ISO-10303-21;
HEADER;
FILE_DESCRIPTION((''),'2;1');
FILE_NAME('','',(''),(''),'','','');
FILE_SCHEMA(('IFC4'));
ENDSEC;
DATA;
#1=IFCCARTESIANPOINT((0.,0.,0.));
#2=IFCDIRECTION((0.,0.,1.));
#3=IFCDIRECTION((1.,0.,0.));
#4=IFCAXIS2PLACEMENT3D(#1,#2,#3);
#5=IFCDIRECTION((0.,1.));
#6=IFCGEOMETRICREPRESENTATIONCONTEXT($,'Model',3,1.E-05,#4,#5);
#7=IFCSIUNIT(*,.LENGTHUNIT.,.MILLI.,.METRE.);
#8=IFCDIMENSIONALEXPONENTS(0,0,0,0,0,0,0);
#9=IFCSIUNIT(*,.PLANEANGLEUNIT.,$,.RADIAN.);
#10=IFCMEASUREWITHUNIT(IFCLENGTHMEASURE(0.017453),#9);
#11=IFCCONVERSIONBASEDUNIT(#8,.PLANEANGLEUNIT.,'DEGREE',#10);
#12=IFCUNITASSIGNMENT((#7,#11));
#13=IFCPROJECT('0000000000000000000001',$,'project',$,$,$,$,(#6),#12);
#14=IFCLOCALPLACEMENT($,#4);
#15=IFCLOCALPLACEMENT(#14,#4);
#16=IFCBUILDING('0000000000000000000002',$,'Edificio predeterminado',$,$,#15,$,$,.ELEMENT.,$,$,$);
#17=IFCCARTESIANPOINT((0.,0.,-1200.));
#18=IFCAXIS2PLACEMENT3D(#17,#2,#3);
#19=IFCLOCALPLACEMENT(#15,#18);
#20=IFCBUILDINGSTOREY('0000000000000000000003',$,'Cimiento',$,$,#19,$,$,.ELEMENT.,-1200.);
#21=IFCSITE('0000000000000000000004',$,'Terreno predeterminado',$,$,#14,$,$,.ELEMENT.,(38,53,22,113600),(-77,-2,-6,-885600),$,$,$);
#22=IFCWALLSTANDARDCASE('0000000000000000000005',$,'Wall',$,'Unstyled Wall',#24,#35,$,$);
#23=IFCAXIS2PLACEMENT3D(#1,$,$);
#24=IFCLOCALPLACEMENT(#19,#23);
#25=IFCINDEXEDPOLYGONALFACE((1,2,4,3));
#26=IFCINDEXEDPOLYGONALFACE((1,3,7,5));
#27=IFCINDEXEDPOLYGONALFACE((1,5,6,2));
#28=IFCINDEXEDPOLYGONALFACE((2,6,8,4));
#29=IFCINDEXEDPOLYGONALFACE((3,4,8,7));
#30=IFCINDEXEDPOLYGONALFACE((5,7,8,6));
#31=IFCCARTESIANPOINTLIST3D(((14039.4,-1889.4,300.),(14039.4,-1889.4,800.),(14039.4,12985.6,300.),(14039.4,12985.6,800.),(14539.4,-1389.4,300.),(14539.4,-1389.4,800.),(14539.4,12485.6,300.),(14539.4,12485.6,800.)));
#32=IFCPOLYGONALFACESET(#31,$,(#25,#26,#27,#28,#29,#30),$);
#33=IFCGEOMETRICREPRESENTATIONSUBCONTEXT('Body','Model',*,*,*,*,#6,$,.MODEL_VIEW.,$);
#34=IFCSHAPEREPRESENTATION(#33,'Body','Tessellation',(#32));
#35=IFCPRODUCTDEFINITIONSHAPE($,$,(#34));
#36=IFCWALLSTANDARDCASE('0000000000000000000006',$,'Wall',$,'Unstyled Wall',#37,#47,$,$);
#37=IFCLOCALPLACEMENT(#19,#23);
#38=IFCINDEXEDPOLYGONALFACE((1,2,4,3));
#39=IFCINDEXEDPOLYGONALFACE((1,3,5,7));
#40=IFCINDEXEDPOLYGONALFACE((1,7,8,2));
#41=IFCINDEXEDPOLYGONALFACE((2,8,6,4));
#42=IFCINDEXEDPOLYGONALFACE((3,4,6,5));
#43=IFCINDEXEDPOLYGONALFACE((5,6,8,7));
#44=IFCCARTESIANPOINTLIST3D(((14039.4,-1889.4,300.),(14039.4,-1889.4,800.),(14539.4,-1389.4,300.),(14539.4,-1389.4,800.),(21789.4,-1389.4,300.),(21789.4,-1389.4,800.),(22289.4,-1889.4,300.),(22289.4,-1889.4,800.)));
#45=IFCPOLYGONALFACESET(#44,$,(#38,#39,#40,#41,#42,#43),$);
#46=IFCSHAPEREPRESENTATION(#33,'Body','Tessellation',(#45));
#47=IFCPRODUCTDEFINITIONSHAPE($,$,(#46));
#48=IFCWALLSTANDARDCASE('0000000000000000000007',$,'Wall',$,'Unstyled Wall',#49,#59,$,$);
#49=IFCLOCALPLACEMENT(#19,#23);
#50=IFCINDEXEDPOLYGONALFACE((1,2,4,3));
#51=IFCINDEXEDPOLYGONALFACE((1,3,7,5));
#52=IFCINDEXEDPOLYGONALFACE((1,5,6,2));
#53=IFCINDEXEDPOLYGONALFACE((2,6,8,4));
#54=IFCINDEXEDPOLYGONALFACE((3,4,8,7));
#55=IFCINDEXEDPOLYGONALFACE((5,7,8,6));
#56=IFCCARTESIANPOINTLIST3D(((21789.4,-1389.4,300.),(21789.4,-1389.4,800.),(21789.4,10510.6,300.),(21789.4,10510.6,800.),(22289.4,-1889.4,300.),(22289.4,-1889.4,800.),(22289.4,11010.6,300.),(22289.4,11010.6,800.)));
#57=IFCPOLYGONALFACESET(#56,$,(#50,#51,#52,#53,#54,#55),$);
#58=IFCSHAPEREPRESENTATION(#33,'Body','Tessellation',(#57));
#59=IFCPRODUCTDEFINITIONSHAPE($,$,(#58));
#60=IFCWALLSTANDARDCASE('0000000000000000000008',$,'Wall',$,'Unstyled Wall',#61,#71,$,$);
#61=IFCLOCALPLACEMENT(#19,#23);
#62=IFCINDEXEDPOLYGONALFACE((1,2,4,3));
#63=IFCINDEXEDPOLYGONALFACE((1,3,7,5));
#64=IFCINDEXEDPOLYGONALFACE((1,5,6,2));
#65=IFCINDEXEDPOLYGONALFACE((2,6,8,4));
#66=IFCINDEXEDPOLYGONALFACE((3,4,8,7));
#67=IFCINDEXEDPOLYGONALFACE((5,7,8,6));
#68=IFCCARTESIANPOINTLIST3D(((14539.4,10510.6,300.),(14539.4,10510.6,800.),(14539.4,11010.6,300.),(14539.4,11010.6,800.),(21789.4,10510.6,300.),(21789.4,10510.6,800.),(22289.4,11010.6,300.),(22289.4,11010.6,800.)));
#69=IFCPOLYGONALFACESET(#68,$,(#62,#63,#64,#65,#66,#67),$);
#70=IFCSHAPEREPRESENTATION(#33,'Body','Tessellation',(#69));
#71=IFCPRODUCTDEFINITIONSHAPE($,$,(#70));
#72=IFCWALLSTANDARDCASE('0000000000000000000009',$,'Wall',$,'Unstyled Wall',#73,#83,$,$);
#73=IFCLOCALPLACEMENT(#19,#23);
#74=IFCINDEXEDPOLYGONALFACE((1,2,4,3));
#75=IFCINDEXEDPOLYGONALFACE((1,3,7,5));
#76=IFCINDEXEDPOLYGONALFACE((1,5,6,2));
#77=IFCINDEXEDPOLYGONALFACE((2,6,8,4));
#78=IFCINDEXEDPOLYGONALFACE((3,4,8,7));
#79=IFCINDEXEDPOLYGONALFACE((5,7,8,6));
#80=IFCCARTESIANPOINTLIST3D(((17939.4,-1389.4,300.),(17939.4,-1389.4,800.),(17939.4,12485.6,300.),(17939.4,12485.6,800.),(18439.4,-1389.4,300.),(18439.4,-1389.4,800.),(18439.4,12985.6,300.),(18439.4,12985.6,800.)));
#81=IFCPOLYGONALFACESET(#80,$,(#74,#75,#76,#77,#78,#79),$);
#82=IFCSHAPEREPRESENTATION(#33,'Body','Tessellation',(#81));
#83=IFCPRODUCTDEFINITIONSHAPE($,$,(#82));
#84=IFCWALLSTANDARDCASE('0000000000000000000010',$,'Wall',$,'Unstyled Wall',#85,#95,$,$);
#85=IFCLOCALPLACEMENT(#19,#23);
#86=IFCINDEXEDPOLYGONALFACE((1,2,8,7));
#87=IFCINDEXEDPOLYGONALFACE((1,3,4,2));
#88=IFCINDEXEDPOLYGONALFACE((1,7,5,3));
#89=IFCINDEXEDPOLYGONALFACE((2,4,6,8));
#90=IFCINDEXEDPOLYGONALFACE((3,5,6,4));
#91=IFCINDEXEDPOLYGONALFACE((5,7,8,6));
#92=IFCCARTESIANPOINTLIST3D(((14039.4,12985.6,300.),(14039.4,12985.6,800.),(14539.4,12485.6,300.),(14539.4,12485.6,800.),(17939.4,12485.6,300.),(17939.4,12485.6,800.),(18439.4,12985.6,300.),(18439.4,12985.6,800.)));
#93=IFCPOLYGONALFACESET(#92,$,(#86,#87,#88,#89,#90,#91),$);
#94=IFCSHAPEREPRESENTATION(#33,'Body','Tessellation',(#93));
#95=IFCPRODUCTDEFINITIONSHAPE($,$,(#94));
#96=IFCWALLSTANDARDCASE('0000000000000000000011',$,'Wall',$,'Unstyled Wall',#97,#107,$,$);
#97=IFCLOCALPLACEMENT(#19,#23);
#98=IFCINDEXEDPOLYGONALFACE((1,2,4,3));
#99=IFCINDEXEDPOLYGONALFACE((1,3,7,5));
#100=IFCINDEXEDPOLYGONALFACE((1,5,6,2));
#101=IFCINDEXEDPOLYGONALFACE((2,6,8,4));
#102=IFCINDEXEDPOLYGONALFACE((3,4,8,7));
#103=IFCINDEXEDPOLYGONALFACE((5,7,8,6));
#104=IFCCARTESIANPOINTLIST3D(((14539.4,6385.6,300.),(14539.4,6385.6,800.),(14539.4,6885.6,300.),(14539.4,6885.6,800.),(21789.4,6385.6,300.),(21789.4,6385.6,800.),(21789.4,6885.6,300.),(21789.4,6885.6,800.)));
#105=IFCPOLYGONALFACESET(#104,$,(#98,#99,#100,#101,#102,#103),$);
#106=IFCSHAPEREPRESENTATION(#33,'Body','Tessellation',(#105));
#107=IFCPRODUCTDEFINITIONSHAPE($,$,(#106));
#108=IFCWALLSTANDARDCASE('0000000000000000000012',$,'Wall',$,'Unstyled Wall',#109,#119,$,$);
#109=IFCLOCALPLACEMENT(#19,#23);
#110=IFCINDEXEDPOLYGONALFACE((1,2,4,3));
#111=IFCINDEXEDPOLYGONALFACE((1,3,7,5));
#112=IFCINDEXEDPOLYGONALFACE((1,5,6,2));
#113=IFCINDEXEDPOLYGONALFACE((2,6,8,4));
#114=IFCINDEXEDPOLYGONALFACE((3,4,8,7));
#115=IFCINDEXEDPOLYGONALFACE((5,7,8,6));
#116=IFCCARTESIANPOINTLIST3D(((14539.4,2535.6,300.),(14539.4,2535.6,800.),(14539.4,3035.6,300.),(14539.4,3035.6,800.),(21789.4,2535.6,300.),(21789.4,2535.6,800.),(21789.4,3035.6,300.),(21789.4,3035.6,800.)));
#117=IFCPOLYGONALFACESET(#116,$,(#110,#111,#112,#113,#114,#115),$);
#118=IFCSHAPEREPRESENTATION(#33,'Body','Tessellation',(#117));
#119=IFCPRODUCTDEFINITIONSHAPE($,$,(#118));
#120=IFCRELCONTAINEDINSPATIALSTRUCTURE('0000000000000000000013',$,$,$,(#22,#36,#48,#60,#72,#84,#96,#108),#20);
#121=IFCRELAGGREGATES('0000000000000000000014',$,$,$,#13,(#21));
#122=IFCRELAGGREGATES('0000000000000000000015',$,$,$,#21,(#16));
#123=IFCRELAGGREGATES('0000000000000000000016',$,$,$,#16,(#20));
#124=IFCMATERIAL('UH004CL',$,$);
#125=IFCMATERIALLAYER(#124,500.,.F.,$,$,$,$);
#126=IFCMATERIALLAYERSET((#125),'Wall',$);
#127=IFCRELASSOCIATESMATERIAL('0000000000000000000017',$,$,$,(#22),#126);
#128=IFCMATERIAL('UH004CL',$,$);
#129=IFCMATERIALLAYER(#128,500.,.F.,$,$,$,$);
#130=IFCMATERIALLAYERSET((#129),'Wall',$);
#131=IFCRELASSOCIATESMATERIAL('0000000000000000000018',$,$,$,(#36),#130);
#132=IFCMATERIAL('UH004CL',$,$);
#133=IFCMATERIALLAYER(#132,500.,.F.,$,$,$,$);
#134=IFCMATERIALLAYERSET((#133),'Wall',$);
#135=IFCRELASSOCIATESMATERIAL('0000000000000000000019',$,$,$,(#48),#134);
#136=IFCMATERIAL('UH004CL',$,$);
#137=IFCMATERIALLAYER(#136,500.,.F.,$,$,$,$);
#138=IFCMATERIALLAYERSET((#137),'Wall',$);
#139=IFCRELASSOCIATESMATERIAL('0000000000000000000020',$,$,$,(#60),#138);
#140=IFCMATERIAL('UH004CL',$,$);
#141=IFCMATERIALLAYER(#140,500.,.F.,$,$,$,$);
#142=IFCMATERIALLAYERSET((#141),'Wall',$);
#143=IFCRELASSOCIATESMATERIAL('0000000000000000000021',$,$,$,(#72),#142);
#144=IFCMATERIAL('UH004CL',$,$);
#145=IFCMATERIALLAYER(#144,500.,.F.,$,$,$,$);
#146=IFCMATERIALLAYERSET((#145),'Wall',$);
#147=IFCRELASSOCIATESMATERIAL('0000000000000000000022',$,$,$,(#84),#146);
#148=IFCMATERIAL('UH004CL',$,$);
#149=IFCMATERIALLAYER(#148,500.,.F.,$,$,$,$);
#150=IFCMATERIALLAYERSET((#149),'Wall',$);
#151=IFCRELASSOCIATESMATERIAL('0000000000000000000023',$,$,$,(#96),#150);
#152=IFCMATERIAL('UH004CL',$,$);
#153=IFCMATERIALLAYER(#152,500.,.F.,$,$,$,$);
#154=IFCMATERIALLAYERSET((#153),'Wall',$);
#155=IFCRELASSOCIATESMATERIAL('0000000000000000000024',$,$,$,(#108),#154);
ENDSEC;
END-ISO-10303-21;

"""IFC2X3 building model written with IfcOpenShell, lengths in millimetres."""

from ifc_helpers import new_model, entity, si_unit, converted_unit, direction, frame, origin_with_axes, place, context, subcontext, project, spatial, polyline, outline, extrude, material, layer, layer_set, layer_usage, element, save


model = new_model("IFC2X3")

# Units and contexts
model_context = context("Model", 3, precision=1e-05, world=origin_with_axes(), true_north=direction((0.0, 1.0)))
body_context = subcontext(model_context, "Body", "Model", "MODEL_VIEW")
ifc_project = project(units=[si_unit("LENGTHUNIT", "METRE", prefix="MILLI"), converted_unit("PLANEANGLEUNIT", "DEGREE", entity("IfcLengthMeasure", 0.017453), si_unit("PLANEANGLEUNIT", "RADIAN"), dimensions=[0, 0, 0, 0, 0, 0, 0])], contexts=[model_context])

# Site, building, storey
site_placement = place(None, origin_with_axes())
site = spatial("IfcSite", under=ifc_project, at=site_placement, Name="Terreno predeterminado", CompositionType="ELEMENT", RefLatitude=(38, 53, 22, 113600), RefLongitude=(-77, -2, -6, -885600))
building_placement = place(site_placement, origin_with_axes())
building = spatial("IfcBuilding", under=site, at=building_placement, Name="Edificio predeterminado", CompositionType="ELEMENT")
storey_placement = place(building_placement, frame((0.0, 0.0, -1200.0), z_axis=(0.0, 0.0, 1.0), x_axis=(1.0, 0.0, 0.0)))
storey = spatial("IfcBuildingStorey", under=building, at=storey_placement, Name="Cimiento", CompositionType="ELEMENT", Elevation=-1200.0)

# Walls
ifc_material_1 = material(Name="UH004CL")
ifc_layer_1 = layer(ifc_material_1, 500.0, ventilated=False)
ifc_layer_set_1 = layer_set([ifc_layer_1], Name="Wall")
ifc_layer_usage_1 = layer_usage(ifc_layer_set_1, "AXIS2", "POSITIVE", -250.0)
wall_1_placement = place(storey_placement, frame((14289.4, 12735.6, 300.0), z_axis=(0.0, 0.0, 1.0), x_axis=(0.0, -1.0, 0.0)))
element("IfcWallStandardCase", 1, at=wall_1_placement, inside=storey, material=ifc_layer_usage_1, Name="Wall", ObjectType="Unstyled Wall", context=body_context, shape_type="SweptSolid", body=[
    extrude(outline(polyline([(250.0, 250.0), (-250.0, -250.0), (14625.0, -250.0), (14125.0, 250.0), (250.0, 250.0)])), origin_with_axes(), (0.0, 0.0, 1.0), 500.0),
])
ifc_material_2 = material(Name="UH004CL")
ifc_layer_2 = layer(ifc_material_2, 500.0, ventilated=False)
ifc_layer_set_2 = layer_set([ifc_layer_2], Name="Wall")
ifc_layer_usage_2 = layer_usage(ifc_layer_set_2, "AXIS2", "POSITIVE", -250.0)
wall_2_placement = place(storey_placement, frame((14289.4, -1639.4, 300.0), z_axis=(0.0, 0.0, 1.0), x_axis=(1.0, 0.0, 0.0)))
element("IfcWallStandardCase", 2, at=wall_2_placement, inside=storey, material=ifc_layer_usage_2, Name="Wall", ObjectType="Unstyled Wall", context=body_context, shape_type="SweptSolid", body=[
    extrude(outline(polyline([(-250.0, -250.0), (250.0, 250.0), (7500.0, 250.0), (8000.0, -250.0), (-250.0, -250.0)])), origin_with_axes(), (0.0, 0.0, 1.0), 500.0),
])
ifc_material_3 = material(Name="UH004CL")
ifc_layer_3 = layer(ifc_material_3, 500.0, ventilated=False)
ifc_layer_set_3 = layer_set([ifc_layer_3], Name="Wall")
ifc_layer_usage_3 = layer_usage(ifc_layer_set_3, "AXIS2", "POSITIVE", -250.0)
wall_3_placement = place(storey_placement, frame((22039.4, -1639.4, 300.0), z_axis=(0.0, 0.0, 1.0), x_axis=(0.0, 1.0, 0.0)))
element("IfcWallStandardCase", 3, at=wall_3_placement, inside=storey, material=ifc_layer_usage_3, Name="Wall", ObjectType="Unstyled Wall", context=body_context, shape_type="SweptSolid", body=[
    extrude(outline(polyline([(-250.0, -250.0), (250.0, 250.0), (12150.0, 250.0), (12650.0, -250.0), (-250.0, -250.0)])), origin_with_axes(), (0.0, 0.0, 1.0), 500.0),
])
ifc_material_4 = material(Name="UH004CL")
ifc_layer_4 = layer(ifc_material_4, 500.0, ventilated=False)
ifc_layer_set_4 = layer_set([ifc_layer_4], Name="Wall")
ifc_layer_usage_4 = layer_usage(ifc_layer_set_4, "AXIS2", "POSITIVE", -250.0)
wall_4_placement = place(storey_placement, frame((22039.4, 10760.6, 300.0), z_axis=(0.0, 0.0, 1.0), x_axis=(-1.0, 0.0, 0.0)))
element("IfcWallStandardCase", 4, at=wall_4_placement, inside=storey, material=ifc_layer_usage_4, Name="Wall", ObjectType="Unstyled Wall", context=body_context, shape_type="SweptSolid", body=[
    extrude(outline(polyline([(-250.0, -250.0), (250.0, 250.0), (7500.0, 250.0), (7500.0, -250.0), (-250.0, -250.0)])), origin_with_axes(), (0.0, 0.0, 1.0), 500.0),
])
ifc_material_5 = material(Name="UH004CL")
ifc_layer_5 = layer(ifc_material_5, 500.0, ventilated=False)
ifc_layer_set_5 = layer_set([ifc_layer_5], Name="Wall")
ifc_layer_usage_5 = layer_usage(ifc_layer_set_5, "AXIS2", "POSITIVE", -250.0)
wall_5_placement = place(storey_placement, frame((18189.4, -1639.4, 300.0), z_axis=(0.0, 0.0, 1.0), x_axis=(0.0, 1.0, 0.0)))
element("IfcWallStandardCase", 5, at=wall_5_placement, inside=storey, material=ifc_layer_usage_5, Name="Wall", ObjectType="Unstyled Wall", context=body_context, shape_type="SweptSolid", body=[
    extrude(outline(polyline([(250.0, 250.0), (250.0, -250.0), (14625.0, -250.0), (14125.0, 250.0), (250.0, 250.0)])), origin_with_axes(), (0.0, 0.0, 1.0), 500.0),
])
ifc_material_6 = material(Name="UH004CL")
ifc_layer_6 = layer(ifc_material_6, 500.0, ventilated=False)
ifc_layer_set_6 = layer_set([ifc_layer_6], Name="Wall")
ifc_layer_usage_6 = layer_usage(ifc_layer_set_6, "AXIS2", "POSITIVE", -250.0)
wall_6_placement = place(storey_placement, frame((18189.4, 12735.6, 300.0), z_axis=(0.0, 0.0, 1.0), x_axis=(-1.0, 0.0, 0.0)))
element("IfcWallStandardCase", 6, at=wall_6_placement, inside=storey, material=ifc_layer_usage_6, Name="Wall", ObjectType="Unstyled Wall", context=body_context, shape_type="SweptSolid", body=[
    extrude(outline(polyline([(-250.0, -250.0), (250.0, 250.0), (3650.0, 250.0), (4150.0, -250.0), (-250.0, -250.0)])), origin_with_axes(), (0.0, 0.0, 1.0), 500.0),
])
ifc_material_7 = material(Name="UH004CL")
ifc_layer_7 = layer(ifc_material_7, 500.0, ventilated=False)
ifc_layer_set_7 = layer_set([ifc_layer_7], Name="Wall")
ifc_layer_usage_7 = layer_usage(ifc_layer_set_7, "AXIS2", "POSITIVE", -250.0)
wall_7_placement = place(storey_placement, frame((14289.4, 6635.6, 300.0), z_axis=(0.0, 0.0, 1.0), x_axis=(1.0, 0.0, 0.0)))
element("IfcWallStandardCase", 7, at=wall_7_placement, inside=storey, material=ifc_layer_usage_7, Name="Wall", ObjectType="Unstyled Wall", context=body_context, shape_type="SweptSolid", body=[
    extrude(outline(polyline([(250.0, -250.0), (250.0, 250.0), (7500.0, 250.0), (7500.0, -250.0), (250.0, -250.0)])), origin_with_axes(), (0.0, 0.0, 1.0), 500.0),
])
ifc_material_8 = material(Name="UH004CL")
ifc_layer_8 = layer(ifc_material_8, 500.0, ventilated=False)
ifc_layer_set_8 = layer_set([ifc_layer_8], Name="Wall")
ifc_layer_usage_8 = layer_usage(ifc_layer_set_8, "AXIS2", "POSITIVE", -250.0)
wall_8_placement = place(storey_placement, frame((14289.4, 2785.6, 300.0), z_axis=(0.0, 0.0, 1.0), x_axis=(1.0, 0.0, 0.0)))
element("IfcWallStandardCase", 8, at=wall_8_placement, inside=storey, material=ifc_layer_usage_8, Name="Wall", ObjectType="Unstyled Wall", context=body_context, shape_type="SweptSolid", body=[
    extrude(outline(polyline([(250.0, -250.0), (250.0, 250.0), (7500.0, 250.0), (7500.0, -250.0), (250.0, -250.0)])), origin_with_axes(), (0.0, 0.0, 1.0), 500.0),
])

save(model, "model.ifc")
